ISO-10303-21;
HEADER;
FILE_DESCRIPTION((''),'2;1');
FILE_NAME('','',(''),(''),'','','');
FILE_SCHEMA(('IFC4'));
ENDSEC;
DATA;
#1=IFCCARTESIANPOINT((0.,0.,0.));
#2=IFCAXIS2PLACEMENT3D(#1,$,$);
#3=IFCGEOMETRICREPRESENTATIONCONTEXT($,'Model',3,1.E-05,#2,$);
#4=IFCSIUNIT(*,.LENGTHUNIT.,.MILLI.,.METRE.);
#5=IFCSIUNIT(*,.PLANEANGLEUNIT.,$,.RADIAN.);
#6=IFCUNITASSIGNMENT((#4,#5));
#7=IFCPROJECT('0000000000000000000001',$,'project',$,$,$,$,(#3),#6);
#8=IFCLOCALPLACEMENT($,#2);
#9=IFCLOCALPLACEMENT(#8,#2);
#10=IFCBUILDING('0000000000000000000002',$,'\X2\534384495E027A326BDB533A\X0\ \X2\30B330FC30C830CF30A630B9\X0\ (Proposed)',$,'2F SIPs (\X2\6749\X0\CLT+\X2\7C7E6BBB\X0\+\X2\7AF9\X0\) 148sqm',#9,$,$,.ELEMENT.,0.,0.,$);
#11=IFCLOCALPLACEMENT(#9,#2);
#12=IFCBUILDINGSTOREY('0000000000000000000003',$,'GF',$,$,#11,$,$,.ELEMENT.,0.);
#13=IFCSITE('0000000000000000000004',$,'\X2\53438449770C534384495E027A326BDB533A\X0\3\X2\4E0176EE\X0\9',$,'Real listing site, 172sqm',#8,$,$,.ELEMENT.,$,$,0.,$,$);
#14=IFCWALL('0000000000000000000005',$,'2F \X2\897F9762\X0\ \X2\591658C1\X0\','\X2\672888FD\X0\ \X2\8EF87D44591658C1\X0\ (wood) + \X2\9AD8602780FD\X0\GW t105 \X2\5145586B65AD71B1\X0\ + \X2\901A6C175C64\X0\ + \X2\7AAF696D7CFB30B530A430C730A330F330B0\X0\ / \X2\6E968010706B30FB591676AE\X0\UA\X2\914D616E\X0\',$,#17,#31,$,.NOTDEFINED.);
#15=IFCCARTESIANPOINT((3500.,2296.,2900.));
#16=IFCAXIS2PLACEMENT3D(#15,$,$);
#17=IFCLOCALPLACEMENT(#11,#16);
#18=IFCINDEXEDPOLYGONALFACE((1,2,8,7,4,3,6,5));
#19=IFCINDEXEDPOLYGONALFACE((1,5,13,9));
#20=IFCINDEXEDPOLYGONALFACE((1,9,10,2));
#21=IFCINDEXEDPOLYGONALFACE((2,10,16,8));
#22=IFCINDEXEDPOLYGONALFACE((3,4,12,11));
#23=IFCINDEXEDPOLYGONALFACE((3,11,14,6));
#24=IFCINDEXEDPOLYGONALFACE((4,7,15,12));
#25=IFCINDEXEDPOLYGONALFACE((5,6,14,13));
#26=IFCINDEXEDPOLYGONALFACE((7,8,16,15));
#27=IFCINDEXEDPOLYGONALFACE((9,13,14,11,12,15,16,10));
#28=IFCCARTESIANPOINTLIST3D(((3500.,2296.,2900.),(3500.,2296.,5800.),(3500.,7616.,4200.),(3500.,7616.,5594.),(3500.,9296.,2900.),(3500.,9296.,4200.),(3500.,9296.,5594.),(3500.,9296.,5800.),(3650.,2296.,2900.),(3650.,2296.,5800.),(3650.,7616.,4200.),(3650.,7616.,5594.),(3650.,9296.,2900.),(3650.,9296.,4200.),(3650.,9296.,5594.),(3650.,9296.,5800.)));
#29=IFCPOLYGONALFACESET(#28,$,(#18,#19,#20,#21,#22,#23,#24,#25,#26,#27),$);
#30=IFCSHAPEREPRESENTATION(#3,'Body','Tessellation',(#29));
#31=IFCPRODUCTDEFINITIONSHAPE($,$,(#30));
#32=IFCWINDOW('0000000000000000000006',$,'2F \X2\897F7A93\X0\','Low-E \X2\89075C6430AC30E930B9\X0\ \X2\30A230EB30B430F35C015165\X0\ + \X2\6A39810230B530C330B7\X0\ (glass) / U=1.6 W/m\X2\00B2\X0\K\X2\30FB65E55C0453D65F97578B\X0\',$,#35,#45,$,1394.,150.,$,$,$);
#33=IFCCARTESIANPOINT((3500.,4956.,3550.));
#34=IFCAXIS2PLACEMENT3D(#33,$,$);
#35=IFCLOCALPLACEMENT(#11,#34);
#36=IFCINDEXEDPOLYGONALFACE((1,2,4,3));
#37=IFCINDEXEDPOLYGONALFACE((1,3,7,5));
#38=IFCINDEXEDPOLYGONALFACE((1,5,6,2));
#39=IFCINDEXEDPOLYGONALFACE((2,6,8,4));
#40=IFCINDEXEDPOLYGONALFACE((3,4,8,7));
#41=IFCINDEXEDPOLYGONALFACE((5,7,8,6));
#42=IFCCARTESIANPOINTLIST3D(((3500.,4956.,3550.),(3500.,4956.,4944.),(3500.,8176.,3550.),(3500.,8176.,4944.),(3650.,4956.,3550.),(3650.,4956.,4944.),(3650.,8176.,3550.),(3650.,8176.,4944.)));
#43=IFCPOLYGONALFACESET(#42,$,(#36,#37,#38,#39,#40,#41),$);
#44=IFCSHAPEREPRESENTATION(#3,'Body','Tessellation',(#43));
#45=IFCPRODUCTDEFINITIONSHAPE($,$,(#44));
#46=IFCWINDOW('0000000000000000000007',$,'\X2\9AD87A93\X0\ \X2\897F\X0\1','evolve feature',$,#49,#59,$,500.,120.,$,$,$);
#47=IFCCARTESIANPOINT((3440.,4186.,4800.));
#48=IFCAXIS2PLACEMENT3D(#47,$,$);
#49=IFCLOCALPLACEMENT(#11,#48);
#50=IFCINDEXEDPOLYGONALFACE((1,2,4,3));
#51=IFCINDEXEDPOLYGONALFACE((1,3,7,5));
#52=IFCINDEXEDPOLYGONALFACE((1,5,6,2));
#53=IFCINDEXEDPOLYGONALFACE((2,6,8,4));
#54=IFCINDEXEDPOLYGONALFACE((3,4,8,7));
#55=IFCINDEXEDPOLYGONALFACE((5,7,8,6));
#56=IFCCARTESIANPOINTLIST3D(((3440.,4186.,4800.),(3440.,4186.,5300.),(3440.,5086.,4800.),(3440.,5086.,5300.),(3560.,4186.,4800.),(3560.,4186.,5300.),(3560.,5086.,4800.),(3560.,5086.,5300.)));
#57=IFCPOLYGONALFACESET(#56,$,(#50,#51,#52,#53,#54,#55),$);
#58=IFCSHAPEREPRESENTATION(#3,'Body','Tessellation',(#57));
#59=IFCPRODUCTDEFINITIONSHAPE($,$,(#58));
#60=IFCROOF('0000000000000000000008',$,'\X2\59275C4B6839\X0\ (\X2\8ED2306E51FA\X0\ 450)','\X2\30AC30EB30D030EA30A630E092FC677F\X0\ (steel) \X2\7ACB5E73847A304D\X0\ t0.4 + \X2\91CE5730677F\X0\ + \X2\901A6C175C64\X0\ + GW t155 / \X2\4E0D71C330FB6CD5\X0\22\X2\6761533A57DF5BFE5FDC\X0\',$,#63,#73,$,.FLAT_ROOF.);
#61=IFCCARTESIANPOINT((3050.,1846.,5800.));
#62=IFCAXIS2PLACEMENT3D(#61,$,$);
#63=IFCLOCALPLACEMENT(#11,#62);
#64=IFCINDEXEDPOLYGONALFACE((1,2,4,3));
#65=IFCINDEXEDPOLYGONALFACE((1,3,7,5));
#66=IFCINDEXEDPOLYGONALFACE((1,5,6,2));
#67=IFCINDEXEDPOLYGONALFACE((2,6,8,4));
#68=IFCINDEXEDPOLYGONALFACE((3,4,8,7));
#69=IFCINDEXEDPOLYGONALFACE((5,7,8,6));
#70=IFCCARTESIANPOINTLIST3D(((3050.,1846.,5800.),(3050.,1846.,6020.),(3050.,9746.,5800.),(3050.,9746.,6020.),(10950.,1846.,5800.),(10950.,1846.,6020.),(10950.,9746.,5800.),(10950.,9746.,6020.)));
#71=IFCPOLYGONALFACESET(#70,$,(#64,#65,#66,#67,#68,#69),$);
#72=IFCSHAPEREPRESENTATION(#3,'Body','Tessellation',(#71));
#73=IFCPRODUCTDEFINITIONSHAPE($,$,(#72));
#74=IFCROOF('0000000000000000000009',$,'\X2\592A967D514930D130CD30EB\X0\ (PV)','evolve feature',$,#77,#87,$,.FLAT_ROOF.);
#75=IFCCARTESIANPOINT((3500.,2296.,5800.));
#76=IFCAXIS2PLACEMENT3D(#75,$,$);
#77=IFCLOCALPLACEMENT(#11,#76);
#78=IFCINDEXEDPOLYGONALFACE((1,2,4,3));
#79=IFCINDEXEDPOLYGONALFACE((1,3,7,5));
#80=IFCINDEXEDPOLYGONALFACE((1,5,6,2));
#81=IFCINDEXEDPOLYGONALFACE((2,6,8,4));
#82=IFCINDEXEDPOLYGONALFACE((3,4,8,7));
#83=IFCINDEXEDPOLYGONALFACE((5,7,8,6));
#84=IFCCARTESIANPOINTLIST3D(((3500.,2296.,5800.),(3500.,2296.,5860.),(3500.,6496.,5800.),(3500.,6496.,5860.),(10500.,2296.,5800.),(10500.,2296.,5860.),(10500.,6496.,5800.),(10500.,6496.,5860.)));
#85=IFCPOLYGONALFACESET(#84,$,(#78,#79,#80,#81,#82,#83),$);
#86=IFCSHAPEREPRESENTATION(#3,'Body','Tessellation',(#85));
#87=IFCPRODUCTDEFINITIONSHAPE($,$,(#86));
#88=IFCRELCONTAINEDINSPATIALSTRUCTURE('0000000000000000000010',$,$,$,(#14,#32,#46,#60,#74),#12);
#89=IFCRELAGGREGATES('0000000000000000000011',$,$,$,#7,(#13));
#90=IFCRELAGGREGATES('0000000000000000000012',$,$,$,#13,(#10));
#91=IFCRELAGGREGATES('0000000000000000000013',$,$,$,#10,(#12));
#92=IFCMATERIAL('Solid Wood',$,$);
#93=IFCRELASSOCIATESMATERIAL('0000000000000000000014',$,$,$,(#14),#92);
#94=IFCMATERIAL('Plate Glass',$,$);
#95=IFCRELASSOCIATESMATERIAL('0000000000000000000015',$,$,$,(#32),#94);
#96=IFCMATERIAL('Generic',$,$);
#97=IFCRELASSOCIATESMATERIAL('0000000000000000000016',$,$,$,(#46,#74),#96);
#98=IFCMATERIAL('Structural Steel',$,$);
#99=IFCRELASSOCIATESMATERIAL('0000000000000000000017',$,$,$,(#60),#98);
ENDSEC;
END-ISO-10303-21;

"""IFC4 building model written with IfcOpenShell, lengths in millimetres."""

from ifc_helpers import new_model, si_unit, frame, frame_2d, origin, place, context, project, spatial, rectangle, extrude, material, element, fill, save


model = new_model("IFC4")

# Units and contexts
model_context = context("Model", 3, precision=1e-05, world=origin())
ifc_project = project(units=[si_unit("LENGTHUNIT", "METRE", prefix="MILLI"), si_unit("PLANEANGLEUNIT", "RADIAN")], contexts=[model_context])

# Site, building, storey
site_placement = place(None, origin())
site = spatial("IfcSite", under=ifc_project, at=site_placement, Name="千葉県千葉市稲毛区3丁目9", ObjectType="Real listing site, 172sqm", CompositionType="ELEMENT", RefElevation=0.0)
building_placement = place(site_placement, origin())
building = spatial("IfcBuilding", under=site, at=building_placement, Name="千葉市稲毛区 コートハウス (Proposed)", ObjectType="2F SIPs (杉CLT+籾殻+竹) 148sqm", CompositionType="ELEMENT", ElevationOfRefHeight=0.0, ElevationOfTerrain=0.0)
storey_placement = place(building_placement, origin())
storey = spatial("IfcBuildingStorey", under=building, at=storey_placement, Name="GF", CompositionType="ELEMENT", Elevation=0.0)

# Shared definitions
ifc_material_1 = material(Name="Solid Wood")
ifc_material_2 = material(Name="Generic")

# Shared definitions
ifc_material_3 = material(Name="Plate Glass")

# Wall, openings, windows
wall_1_placement = place(storey_placement, frame((3500.0, 2296.0, 2900.0)))
wall_1 = element("IfcWall", 1, at=wall_1_placement, inside=storey, material=ifc_material_1, Name="2F 西面 外壁", Description="木製 軸組外壁 (wood) + 高性能GW t105 充填断熱 + 通気層 + 窯業系サイディング / 準耐火・外皮UA配慮", PredefinedType="NOTDEFINED", context=model_context, shape_type="SweptSolid", body=[
    extrude(rectangle(XDim=150.0, YDim=7000.0, at=frame_2d((75.0, 3500.0))), frame((3500.0, 2296.0, 2900.0)), (0.0, 0.0, 1.0), 2900.0),
])
opening_1_placement = place(storey_placement, frame((3500.0, 4956.0, 3550.0)))
opening_1 = element("IfcOpeningElement", 2, at=opening_1_placement, cuts=wall_1, PredefinedType="NOTDEFINED", context=model_context, shape_type="SweptSolid", body=[
    extrude(rectangle(XDim=150.0, YDim=3220.0, at=frame_2d((75.0, 1610.0))), frame((3500.0, 4956.0, 3550.0)), (0.0, 0.0, 1.0), 1394.0),
])
opening_2_placement = place(storey_placement, frame((3440.0, 4186.0, 4800.0)))
opening_2 = element("IfcOpeningElement", 3, at=opening_2_placement, cuts=wall_1, PredefinedType="NOTDEFINED", context=model_context, shape_type="SweptSolid", body=[
    extrude(rectangle(XDim=120.0, YDim=900.0, at=frame_2d((60.0, 450.0))), frame((3440.0, 4186.0, 4800.0)), (0.0, 0.0, 1.0), 500.0),
])
window_1_placement = place(storey_placement, frame((3500.0, 4956.0, 3550.0)))
window_1 = element("IfcWindow", 4, at=window_1_placement, inside=storey, material=ifc_material_3, Name="2F 西窓", Description="Low-E 複層ガラス アルゴン封入 + 樹脂サッシ (glass) / U=1.6 W/m²K・日射取得型", OverallHeight=1394.0, OverallWidth=150.0, context=model_context, shape_type="SweptSolid", body=[
    extrude(rectangle(XDim=150.0, YDim=3220.0, at=frame_2d((75.0, 1610.0))), frame((3500.0, 4956.0, 3550.0)), (0.0, 0.0, 1.0), 1394.0),
])
fill(opening_1, window_1)
window_2_placement = place(storey_placement, frame((3440.0, 4186.0, 4800.0)))
window_2 = element("IfcWindow", 5, at=window_2_placement, inside=storey, material=ifc_material_2, Name="高窓 西1", Description="evolve feature", OverallHeight=500.0, OverallWidth=120.0, context=model_context, shape_type="SweptSolid", body=[
    extrude(rectangle(XDim=120.0, YDim=900.0, at=frame_2d((60.0, 450.0))), frame((3440.0, 4186.0, 4800.0)), (0.0, 0.0, 1.0), 500.0),
])
fill(opening_2, window_2)

# Roofs
ifc_material_4 = material(Name="Structural Steel")
roof_1_placement = place(storey_placement, frame((3050.0, 1846.0, 5800.0)))
element("IfcRoof", 6, at=roof_1_placement, inside=storey, material=ifc_material_4, Name="大屋根 (軒の出 450)", Description="ガルバリウム鋼板 (steel) 立平葺き t0.4 + 野地板 + 通気層 + GW t155 / 不燃・法22条区域対応", PredefinedType="FLAT_ROOF", context=model_context, shape_type="SweptSolid", body=[
    extrude(rectangle(XDim=7900.0, YDim=7900.0, at=frame_2d((3950.0, 3950.0))), frame((3050.0, 1846.0, 5800.0)), (0.0, 0.0, 1.0), 220.0),
])
roof_2_placement = place(storey_placement, frame((3500.0, 2296.0, 5800.0)))
element("IfcRoof", 7, at=roof_2_placement, inside=storey, material=ifc_material_2, Name="太陽光パネル (PV)", Description="evolve feature", PredefinedType="FLAT_ROOF", context=model_context, shape_type="SweptSolid", body=[
    extrude(rectangle(XDim=7000.0, YDim=4200.0, at=frame_2d((3500.0, 2100.0))), frame((3500.0, 2296.0, 5800.0)), (0.0, 0.0, 1.0), 60.0),
])

save(model, "model.ifc")
